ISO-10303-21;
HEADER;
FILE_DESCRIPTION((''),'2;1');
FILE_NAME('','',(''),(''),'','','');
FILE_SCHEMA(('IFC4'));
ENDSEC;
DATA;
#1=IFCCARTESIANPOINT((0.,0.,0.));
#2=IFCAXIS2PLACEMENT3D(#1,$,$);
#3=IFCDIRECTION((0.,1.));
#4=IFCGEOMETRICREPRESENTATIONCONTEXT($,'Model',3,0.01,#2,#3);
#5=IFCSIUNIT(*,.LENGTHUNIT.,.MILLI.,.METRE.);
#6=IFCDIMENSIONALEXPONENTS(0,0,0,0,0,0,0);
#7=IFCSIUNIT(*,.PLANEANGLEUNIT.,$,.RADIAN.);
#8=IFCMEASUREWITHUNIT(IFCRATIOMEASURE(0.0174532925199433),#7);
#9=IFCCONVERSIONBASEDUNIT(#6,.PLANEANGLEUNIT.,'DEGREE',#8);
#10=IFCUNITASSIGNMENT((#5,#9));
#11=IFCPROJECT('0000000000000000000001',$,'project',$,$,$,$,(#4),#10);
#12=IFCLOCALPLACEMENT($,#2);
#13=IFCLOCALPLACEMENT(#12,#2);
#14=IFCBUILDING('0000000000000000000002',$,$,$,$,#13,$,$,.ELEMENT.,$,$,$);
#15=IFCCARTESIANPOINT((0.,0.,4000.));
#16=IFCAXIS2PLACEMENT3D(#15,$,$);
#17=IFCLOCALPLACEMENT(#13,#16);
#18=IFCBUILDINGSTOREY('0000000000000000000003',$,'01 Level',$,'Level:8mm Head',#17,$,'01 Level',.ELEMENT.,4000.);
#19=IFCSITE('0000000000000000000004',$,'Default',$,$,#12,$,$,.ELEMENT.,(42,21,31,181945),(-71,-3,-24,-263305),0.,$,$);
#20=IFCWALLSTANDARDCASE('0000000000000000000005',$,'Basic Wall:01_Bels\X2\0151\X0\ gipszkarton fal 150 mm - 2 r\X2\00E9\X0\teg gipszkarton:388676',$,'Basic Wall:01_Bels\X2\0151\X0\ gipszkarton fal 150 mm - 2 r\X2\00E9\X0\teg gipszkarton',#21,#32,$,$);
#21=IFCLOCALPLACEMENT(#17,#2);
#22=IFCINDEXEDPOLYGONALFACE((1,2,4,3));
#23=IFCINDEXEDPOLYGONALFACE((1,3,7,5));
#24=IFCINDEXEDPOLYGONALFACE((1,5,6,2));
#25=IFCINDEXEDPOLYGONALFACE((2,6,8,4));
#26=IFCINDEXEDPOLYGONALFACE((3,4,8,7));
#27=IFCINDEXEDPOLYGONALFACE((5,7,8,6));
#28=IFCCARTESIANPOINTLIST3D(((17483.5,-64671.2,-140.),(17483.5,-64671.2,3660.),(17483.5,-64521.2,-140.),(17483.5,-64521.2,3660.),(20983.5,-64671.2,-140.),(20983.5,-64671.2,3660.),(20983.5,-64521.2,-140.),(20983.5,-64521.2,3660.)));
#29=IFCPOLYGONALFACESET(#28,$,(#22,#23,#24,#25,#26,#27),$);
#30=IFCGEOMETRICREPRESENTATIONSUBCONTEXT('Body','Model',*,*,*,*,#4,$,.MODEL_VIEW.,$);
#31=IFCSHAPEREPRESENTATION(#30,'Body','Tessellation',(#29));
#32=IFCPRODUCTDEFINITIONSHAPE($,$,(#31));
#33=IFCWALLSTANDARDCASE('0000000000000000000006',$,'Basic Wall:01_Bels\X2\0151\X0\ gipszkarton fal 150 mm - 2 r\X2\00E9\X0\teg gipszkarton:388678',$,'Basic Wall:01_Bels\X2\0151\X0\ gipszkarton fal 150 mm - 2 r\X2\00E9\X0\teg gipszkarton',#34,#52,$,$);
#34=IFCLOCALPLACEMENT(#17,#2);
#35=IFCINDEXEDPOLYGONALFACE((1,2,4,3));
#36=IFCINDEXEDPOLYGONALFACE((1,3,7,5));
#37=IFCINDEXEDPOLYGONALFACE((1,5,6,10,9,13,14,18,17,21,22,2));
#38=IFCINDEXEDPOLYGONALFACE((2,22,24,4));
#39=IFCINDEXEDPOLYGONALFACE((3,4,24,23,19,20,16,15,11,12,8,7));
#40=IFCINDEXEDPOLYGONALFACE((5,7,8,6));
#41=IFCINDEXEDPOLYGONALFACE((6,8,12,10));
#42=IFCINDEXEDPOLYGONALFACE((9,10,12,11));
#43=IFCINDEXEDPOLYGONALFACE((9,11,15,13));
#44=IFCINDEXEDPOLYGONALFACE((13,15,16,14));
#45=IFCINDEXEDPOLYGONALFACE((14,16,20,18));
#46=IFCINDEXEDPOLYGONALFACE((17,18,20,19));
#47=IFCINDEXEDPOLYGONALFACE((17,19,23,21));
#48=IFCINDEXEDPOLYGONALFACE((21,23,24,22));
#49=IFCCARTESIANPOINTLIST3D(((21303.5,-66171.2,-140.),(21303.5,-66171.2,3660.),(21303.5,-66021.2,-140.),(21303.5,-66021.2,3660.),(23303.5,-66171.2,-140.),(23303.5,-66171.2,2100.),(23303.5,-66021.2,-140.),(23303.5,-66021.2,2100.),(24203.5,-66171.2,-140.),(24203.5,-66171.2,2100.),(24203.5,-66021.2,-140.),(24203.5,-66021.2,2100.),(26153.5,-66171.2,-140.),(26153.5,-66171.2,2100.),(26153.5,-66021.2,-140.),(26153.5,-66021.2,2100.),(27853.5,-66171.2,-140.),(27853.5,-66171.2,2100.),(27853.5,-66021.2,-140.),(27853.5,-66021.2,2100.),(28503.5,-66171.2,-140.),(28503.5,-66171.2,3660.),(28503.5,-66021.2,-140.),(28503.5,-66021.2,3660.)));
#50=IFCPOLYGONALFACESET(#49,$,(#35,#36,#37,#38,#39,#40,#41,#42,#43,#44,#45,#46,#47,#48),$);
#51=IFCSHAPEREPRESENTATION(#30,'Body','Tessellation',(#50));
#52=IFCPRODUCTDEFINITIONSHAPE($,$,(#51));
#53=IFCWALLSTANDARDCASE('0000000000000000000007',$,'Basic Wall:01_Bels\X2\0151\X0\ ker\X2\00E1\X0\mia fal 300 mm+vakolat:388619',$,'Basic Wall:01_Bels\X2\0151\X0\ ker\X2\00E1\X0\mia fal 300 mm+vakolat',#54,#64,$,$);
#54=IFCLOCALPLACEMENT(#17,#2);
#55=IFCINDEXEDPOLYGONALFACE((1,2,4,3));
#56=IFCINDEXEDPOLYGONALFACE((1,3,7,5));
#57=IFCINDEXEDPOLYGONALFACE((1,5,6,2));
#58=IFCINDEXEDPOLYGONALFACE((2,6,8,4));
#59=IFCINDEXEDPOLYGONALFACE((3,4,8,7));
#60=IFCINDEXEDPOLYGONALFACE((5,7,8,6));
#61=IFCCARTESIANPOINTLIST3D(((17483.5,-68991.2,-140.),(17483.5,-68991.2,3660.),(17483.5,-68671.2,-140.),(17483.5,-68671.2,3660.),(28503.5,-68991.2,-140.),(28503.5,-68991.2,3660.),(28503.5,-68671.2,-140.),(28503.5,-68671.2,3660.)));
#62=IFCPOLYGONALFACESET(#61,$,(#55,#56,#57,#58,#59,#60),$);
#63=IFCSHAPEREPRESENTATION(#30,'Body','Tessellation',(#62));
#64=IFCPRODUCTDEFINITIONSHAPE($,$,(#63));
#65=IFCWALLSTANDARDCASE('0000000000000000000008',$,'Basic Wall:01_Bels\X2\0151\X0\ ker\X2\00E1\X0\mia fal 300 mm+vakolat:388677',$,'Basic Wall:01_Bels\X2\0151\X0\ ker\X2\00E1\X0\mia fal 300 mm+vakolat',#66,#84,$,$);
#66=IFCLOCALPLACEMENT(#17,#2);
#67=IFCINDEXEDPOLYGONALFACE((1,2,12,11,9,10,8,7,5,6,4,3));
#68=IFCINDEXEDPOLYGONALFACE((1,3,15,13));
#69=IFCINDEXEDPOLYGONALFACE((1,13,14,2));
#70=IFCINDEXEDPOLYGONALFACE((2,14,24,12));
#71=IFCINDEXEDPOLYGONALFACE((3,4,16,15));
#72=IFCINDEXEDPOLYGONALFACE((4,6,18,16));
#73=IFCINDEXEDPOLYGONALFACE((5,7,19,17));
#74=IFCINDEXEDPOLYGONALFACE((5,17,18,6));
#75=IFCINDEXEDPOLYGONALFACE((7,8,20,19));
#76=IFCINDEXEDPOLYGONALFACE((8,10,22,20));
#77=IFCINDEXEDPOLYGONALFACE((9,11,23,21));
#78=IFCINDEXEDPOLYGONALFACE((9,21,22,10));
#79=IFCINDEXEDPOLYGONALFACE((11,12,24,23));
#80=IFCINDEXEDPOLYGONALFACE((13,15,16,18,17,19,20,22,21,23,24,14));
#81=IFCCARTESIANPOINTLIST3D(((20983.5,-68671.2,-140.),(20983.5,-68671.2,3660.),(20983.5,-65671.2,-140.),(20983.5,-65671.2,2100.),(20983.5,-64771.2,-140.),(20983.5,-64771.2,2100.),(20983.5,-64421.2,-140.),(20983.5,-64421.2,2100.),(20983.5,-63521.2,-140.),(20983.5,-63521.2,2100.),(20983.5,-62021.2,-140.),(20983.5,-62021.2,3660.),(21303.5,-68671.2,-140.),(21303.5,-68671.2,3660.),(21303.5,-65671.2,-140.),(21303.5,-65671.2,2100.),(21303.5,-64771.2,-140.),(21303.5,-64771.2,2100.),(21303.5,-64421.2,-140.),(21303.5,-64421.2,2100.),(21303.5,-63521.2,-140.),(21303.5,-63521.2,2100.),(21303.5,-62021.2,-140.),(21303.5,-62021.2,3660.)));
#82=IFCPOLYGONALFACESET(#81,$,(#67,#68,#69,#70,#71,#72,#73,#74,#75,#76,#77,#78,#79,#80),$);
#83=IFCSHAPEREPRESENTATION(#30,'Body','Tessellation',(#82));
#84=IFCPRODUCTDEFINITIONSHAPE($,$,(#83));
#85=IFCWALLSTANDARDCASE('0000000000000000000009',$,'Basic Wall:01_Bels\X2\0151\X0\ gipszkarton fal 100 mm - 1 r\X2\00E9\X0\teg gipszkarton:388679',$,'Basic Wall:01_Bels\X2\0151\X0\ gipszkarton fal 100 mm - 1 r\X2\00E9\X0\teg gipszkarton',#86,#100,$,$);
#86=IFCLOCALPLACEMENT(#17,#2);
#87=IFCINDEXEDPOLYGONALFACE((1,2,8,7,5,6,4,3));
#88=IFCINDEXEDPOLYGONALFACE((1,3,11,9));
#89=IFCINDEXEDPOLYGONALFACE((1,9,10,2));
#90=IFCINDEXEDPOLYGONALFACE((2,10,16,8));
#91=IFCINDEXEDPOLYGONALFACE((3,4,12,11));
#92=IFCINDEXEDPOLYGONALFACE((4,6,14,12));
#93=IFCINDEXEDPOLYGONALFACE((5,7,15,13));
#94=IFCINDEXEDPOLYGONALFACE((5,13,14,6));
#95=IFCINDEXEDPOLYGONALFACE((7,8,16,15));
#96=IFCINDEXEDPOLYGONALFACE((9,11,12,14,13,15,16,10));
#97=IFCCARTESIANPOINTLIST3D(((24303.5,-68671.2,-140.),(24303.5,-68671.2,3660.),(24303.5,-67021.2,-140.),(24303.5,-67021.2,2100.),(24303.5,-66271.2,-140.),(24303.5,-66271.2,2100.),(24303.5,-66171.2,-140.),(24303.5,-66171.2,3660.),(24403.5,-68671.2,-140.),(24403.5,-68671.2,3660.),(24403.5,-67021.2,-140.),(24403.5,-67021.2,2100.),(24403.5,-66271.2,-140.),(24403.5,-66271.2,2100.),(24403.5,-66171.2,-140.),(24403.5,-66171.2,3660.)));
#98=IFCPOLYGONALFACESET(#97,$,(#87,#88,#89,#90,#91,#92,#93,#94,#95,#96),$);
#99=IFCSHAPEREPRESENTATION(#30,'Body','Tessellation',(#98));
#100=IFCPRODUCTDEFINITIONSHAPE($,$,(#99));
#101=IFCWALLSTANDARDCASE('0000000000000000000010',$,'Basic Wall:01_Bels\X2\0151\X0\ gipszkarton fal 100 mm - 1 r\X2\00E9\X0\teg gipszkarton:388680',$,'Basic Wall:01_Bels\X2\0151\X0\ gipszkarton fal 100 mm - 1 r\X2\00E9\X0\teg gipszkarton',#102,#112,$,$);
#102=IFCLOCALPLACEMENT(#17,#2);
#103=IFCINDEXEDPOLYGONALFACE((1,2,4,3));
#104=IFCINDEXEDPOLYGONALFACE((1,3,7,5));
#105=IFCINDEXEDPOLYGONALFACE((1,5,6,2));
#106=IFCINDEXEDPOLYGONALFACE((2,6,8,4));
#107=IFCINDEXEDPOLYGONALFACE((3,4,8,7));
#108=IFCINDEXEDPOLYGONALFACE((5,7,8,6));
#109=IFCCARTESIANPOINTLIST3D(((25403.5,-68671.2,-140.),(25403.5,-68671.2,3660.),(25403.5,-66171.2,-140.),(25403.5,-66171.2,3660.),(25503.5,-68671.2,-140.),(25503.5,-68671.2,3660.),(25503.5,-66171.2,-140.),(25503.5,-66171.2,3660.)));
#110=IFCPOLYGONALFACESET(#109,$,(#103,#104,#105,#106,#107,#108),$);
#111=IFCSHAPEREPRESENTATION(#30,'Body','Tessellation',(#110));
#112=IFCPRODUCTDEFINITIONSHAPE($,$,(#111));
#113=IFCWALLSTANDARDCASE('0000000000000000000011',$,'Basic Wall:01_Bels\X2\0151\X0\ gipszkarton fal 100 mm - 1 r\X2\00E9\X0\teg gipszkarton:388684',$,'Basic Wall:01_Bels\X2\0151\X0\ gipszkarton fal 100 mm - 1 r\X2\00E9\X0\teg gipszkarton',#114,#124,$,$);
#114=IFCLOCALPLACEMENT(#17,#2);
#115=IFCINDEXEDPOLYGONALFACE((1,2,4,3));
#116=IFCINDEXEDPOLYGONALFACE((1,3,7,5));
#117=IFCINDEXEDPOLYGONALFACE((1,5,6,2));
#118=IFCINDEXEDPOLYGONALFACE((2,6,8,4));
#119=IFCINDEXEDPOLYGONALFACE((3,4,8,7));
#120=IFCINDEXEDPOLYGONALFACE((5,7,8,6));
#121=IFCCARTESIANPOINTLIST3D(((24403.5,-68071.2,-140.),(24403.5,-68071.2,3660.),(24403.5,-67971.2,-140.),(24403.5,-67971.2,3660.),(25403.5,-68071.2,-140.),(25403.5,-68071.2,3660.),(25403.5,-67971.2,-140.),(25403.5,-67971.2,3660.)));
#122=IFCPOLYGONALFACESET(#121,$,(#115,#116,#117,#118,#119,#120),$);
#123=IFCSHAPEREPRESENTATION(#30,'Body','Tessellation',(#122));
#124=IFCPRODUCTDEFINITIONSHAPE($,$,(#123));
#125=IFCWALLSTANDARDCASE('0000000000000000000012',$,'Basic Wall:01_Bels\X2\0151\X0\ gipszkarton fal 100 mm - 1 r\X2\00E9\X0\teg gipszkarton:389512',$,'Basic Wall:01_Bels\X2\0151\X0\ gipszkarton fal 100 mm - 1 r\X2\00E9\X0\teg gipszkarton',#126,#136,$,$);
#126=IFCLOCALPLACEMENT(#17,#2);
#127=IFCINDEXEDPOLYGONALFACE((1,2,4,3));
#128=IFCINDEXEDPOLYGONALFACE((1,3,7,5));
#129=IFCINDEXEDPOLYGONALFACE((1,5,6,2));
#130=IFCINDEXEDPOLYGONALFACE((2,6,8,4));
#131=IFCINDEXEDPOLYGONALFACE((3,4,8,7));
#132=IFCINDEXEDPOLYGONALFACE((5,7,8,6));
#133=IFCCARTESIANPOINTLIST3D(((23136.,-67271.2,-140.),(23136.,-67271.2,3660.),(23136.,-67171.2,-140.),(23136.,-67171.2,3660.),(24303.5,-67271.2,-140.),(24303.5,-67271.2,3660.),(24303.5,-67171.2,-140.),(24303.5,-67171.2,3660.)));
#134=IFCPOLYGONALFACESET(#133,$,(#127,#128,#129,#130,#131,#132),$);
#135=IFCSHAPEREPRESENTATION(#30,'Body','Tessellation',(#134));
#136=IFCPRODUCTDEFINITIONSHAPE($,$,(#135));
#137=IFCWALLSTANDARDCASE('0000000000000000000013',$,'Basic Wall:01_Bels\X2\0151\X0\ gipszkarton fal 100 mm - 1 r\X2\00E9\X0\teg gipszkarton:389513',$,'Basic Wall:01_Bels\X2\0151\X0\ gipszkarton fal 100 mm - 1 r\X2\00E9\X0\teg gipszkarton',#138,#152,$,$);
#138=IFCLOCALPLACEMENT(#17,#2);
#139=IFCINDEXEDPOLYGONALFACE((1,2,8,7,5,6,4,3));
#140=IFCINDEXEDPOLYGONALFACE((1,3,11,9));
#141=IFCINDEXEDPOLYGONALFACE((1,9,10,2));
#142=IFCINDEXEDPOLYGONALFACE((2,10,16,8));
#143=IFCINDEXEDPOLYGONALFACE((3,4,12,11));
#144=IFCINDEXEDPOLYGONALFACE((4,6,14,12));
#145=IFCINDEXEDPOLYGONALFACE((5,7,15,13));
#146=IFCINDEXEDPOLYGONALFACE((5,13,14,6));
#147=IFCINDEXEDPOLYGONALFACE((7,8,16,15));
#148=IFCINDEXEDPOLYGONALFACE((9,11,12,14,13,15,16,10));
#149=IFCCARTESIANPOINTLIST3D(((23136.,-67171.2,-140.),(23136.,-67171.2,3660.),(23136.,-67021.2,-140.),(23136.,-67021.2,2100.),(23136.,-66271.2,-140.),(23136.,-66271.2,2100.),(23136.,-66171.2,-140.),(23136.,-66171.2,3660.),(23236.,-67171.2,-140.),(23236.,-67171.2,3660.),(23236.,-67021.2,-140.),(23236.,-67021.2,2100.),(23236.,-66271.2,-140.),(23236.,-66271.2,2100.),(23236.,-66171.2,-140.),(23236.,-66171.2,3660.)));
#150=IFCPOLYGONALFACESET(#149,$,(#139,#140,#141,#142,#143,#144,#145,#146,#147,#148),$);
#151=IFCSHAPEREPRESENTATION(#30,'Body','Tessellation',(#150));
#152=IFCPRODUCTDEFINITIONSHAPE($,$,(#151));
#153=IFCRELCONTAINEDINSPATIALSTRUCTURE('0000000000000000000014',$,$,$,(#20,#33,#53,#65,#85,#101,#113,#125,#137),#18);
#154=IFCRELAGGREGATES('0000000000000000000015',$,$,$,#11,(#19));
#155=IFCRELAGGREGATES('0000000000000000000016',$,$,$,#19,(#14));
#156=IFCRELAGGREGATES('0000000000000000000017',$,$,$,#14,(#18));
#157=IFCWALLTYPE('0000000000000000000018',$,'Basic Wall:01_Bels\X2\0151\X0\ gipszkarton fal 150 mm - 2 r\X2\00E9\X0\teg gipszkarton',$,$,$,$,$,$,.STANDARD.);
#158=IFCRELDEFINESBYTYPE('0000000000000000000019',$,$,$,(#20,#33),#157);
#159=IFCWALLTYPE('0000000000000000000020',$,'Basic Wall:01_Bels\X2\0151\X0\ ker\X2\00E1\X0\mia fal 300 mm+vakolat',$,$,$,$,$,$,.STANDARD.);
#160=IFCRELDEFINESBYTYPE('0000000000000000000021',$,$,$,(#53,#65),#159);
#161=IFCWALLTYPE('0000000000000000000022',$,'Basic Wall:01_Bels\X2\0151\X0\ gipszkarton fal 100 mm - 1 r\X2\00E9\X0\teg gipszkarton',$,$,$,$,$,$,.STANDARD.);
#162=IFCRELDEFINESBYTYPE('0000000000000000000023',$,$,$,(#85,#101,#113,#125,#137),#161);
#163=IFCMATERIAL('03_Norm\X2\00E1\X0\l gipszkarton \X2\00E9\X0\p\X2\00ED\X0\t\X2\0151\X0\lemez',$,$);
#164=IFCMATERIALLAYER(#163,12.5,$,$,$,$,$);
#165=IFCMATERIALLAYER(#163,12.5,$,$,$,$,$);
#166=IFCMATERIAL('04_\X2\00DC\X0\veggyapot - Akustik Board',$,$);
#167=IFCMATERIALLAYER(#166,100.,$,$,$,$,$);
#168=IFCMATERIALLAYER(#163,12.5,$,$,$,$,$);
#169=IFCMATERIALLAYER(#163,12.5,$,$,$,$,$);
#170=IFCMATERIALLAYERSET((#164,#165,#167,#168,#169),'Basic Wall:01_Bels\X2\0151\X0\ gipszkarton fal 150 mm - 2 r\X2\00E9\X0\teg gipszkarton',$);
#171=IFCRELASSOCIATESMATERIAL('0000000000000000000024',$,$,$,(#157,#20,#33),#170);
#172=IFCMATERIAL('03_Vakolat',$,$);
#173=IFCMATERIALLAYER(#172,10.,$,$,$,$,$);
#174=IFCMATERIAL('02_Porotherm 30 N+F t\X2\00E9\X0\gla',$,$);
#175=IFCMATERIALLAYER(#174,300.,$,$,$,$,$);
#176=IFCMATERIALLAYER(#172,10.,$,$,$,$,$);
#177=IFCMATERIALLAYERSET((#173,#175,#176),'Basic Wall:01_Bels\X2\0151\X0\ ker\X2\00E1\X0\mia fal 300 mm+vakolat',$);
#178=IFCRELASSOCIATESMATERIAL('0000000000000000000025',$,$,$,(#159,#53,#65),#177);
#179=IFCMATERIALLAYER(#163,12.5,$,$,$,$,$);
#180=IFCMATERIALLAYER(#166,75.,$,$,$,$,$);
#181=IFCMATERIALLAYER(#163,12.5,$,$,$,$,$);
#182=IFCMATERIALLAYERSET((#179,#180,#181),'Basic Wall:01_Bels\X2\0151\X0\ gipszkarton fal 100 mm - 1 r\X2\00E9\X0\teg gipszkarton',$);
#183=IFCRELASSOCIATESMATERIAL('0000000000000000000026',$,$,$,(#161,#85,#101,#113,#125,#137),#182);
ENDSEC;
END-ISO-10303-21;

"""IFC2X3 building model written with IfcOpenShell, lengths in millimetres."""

from ifc_helpers import new_model, entity, si_unit, converted_unit, direction, frame, frame_2d, origin, origin_2d_with_axis, place, context, subcontext, project, spatial, rectangle, extrude, material, layer, layer_set, layer_usage, type_object, element, save


model = new_model("IFC2X3")

# Units and contexts
model_context = context("Model", 3, precision=0.01, world=origin(), true_north=direction((0.0, 1.0)))
body_context = subcontext(model_context, "Body", "Model", "MODEL_VIEW")
ifc_project = project(units=[si_unit("LENGTHUNIT", "METRE", prefix="MILLI"), converted_unit("PLANEANGLEUNIT", "DEGREE", entity("IfcRatioMeasure", 0.0174532925199433), si_unit("PLANEANGLEUNIT", "RADIAN"), dimensions=[0, 0, 0, 0, 0, 0, 0])], contexts=[model_context])

# Site, building, storey
site_placement = place(None, origin())
site = spatial("IfcSite", under=ifc_project, at=site_placement, Name="Default", CompositionType="ELEMENT", RefLatitude=(42, 21, 31, 181945), RefLongitude=(-71, -3, -24, -263305), RefElevation=0.0)
building_placement = place(site_placement, origin())
building = spatial("IfcBuilding", under=site, at=building_placement, CompositionType="ELEMENT")
storey_placement = place(building_placement, frame((0.0, 0.0, 4000.0)))
storey = spatial("IfcBuildingStorey", under=building, at=storey_placement, Name="01 Level", ObjectType="Level:8mm Head", LongName="01 Level", CompositionType="ELEMENT", Elevation=4000.0)

# Wall
ifc_material_1 = material(Name="03_Normál gipszkarton építőlemez")
ifc_layer_1 = layer(ifc_material_1, 12.5)
ifc_layer_2 = layer(ifc_material_1, 12.5)
ifc_material_2 = material(Name="04_Üveggyapot - Akustik Board")
ifc_layer_3 = layer(ifc_material_2, 100.0)
ifc_layer_4 = layer(ifc_material_1, 12.5)
ifc_layer_5 = layer(ifc_material_1, 12.5)
ifc_layer_set_1 = layer_set([ifc_layer_1, ifc_layer_2, ifc_layer_3, ifc_layer_4, ifc_layer_5], Name="Basic Wall:01_Belső gipszkarton fal 150 mm - 2 réteg gipszkarton")
ifc_layer_usage_1 = layer_usage(ifc_layer_set_1, "AXIS2", "POSITIVE", -75.0)
wall_type_1 = type_object("IfcWallType", Name="Basic Wall:01_Belső gipszkarton fal 150 mm - 2 réteg gipszkarton", PredefinedType="STANDARD", material=ifc_layer_set_1)
wall_1_placement = place(storey_placement, frame((17483.5, -64596.2, -140.0)))
element("IfcWallStandardCase", 1, at=wall_1_placement, inside=storey, type_object=wall_type_1, material=ifc_layer_usage_1, Name="Basic Wall:01_Belső gipszkarton fal 150 mm - 2 réteg gipszkarton:388676", ObjectType="Basic Wall:01_Belső gipszkarton fal 150 mm - 2 réteg gipszkarton", context=body_context, shape_type="SweptSolid", body=[
    extrude(rectangle(XDim=3500.0, YDim=150.0, at=frame_2d((1750.0, 0.0), x_axis=(-1.0, 0.0))), origin(), (0.0, 0.0, 1.0), 3800.0),
])

# Wall, openings
ifc_layer_usage_2 = layer_usage(ifc_layer_set_1, "AXIS2", "POSITIVE", -75.0)
wall_2_placement = place(storey_placement, frame((21303.5, -66096.2, -140.0)))
wall_2 = element("IfcWallStandardCase", 2, at=wall_2_placement, inside=storey, type_object=wall_type_1, material=ifc_layer_usage_2, Name="Basic Wall:01_Belső gipszkarton fal 150 mm - 2 réteg gipszkarton:388678", ObjectType="Basic Wall:01_Belső gipszkarton fal 150 mm - 2 réteg gipszkarton", context=body_context, shape_type="SweptSolid", body=[
    extrude(rectangle(XDim=7200.0, YDim=150.0, at=frame_2d((3600.0, 0.0), x_axis=(-1.0, 0.0))), origin(), (0.0, 0.0, 1.0), 3800.0),
])
opening_1_placement = place(wall_2_placement, frame((4850.0, -75.0, 0.0)))
element("IfcOpeningElement", 3, at=opening_1_placement, cuts=wall_2, ObjectType="Opening", context=body_context, shape_type="SweptSolid", body=[
    extrude(rectangle(XDim=2240.0, YDim=1700.0, at=frame_2d((0.0, 0.0), x_axis=(1.0, 0.0))), frame((850.0, 0.0, 1120.0), z_axis=(0.0, 1.0, 0.0), x_axis=(0.0, 0.0, -1.0)), (0.0, 0.0, 1.0), 150.0),
])
opening_2_placement = place(wall_2_placement, frame((2000.0, -1599.0, 0.0)))
element("IfcOpeningElement", 4, at=opening_2_placement, cuts=wall_2, ObjectType="Opening", context=body_context, shape_type="SweptSolid", body=[
    extrude(rectangle(XDim=2240.0, YDim=900.0, at=frame_2d((0.0, 0.0), x_axis=(0.0, 1.0))), frame((450.0, 0.0, 1120.0), z_axis=(0.0, 1.0, 0.0), x_axis=(-1.0, 0.0, 0.0)), (0.0, 0.0, 1.0), 3048.0),
])

# Wall
ifc_material_3 = material(Name="03_Vakolat")
ifc_layer_6 = layer(ifc_material_3, 10.0)
ifc_material_4 = material(Name="02_Porotherm 30 N+F tégla")
ifc_layer_7 = layer(ifc_material_4, 300.0)
ifc_layer_8 = layer(ifc_material_3, 10.0)
ifc_layer_set_2 = layer_set([ifc_layer_6, ifc_layer_7, ifc_layer_8], Name="Basic Wall:01_Belső kerámia fal 300 mm+vakolat")
ifc_layer_usage_3 = layer_usage(ifc_layer_set_2, "AXIS2", "NEGATIVE", 160.0)
wall_type_2 = type_object("IfcWallType", Name="Basic Wall:01_Belső kerámia fal 300 mm+vakolat", PredefinedType="STANDARD", material=ifc_layer_set_2)
wall_3_placement = place(storey_placement, frame((17483.5, -68831.2, -140.0)))
element("IfcWallStandardCase", 5, at=wall_3_placement, inside=storey, type_object=wall_type_2, material=ifc_layer_usage_3, Name="Basic Wall:01_Belső kerámia fal 300 mm+vakolat:388619", ObjectType="Basic Wall:01_Belső kerámia fal 300 mm+vakolat", context=body_context, shape_type="SweptSolid", body=[
    extrude(rectangle(XDim=11020.0, YDim=320.0, at=frame_2d((5510.0, 0.0), x_axis=(-1.0, 0.0))), origin(), (0.0, 0.0, 1.0), 3800.0),
])

# Wall, openings
ifc_layer_usage_4 = layer_usage(ifc_layer_set_2, "AXIS2", "POSITIVE", -160.0)
wall_4_placement = place(storey_placement, frame((21143.5, -68671.2, -140.0), z_axis=(0.0, 0.0, 1.0), x_axis=(0.0, 1.0, 0.0)))
wall_4 = element("IfcWallStandardCase", 6, at=wall_4_placement, inside=storey, type_object=wall_type_2, material=ifc_layer_usage_4, Name="Basic Wall:01_Belső kerámia fal 300 mm+vakolat:388677", ObjectType="Basic Wall:01_Belső kerámia fal 300 mm+vakolat", context=body_context, shape_type="SweptSolid", body=[
    extrude(rectangle(XDim=6650.0, YDim=320.0, at=frame_2d((3325.0, 0.0), x_axis=(-1.0, 0.0))), origin(), (0.0, 0.0, 1.0), 3800.0),
])
opening_3_placement = place(wall_4_placement, frame((3000.0, 1364.0, 0.0), z_axis=(0.0, 0.0, 1.0), x_axis=(0.0, -1.0, 0.0)))
element("IfcOpeningElement", 7, at=opening_3_placement, cuts=wall_4, ObjectType="Opening", context=body_context, shape_type="SweptSolid", body=[
    extrude(rectangle(XDim=2240.0, YDim=900.0, at=origin_2d_with_axis()), frame((3048.0, 450.0, 1120.0), z_axis=(-1.0, 0.0, 0.0), x_axis=(0.0, 0.0, 1.0)), (0.0, 0.0, 1.0), 3048.0),
])
opening_4_placement = place(wall_4_placement, frame((4250.0, 1364.0, 0.0), z_axis=(0.0, 0.0, 1.0), x_axis=(0.0, -1.0, 0.0)))
element("IfcOpeningElement", 8, at=opening_4_placement, cuts=wall_4, ObjectType="Opening", context=body_context, shape_type="SweptSolid", body=[
    extrude(rectangle(XDim=2240.0, YDim=900.0, at=frame_2d((0.0, 0.0), x_axis=(0.0, 1.0))), frame((3048.0, 450.0, 1120.0), z_axis=(-1.0, 0.0, 0.0), x_axis=(0.0, -1.0, 0.0)), (0.0, 0.0, 1.0), 3048.0),
])

# Wall, opening
ifc_layer_9 = layer(ifc_material_1, 12.5)
ifc_layer_10 = layer(ifc_material_2, 75.0)
ifc_layer_11 = layer(ifc_material_1, 12.5)
ifc_layer_set_3 = layer_set([ifc_layer_9, ifc_layer_10, ifc_layer_11], Name="Basic Wall:01_Belső gipszkarton fal 100 mm - 1 réteg gipszkarton")
ifc_layer_usage_5 = layer_usage(ifc_layer_set_3, "AXIS2", "POSITIVE", -50.0)
wall_type_3 = type_object("IfcWallType", Name="Basic Wall:01_Belső gipszkarton fal 100 mm - 1 réteg gipszkarton", PredefinedType="STANDARD", material=ifc_layer_set_3)
wall_5_placement = place(storey_placement, frame((24353.5, -66171.2, -140.0), z_axis=(0.0, 0.0, 1.0), x_axis=(0.0, -1.0, 0.0)))
wall_5 = element("IfcWallStandardCase", 9, at=wall_5_placement, inside=storey, type_object=wall_type_3, material=ifc_layer_usage_5, Name="Basic Wall:01_Belső gipszkarton fal 100 mm - 1 réteg gipszkarton:388679", ObjectType="Basic Wall:01_Belső gipszkarton fal 100 mm - 1 réteg gipszkarton", context=body_context, shape_type="SweptSolid", body=[
    extrude(rectangle(XDim=2500.0, YDim=100.0, at=frame_2d((1250.0, 0.0), x_axis=(-1.0, 0.0))), origin(), (0.0, 0.0, 1.0), 3800.0),
])
opening_5_placement = place(wall_5_placement, frame((850.0, -1574.0, 0.0), z_axis=(0.0, 0.0, 1.0), x_axis=(0.0, 1.0, 0.0)))
element("IfcOpeningElement", 10, at=opening_5_placement, cuts=wall_5, ObjectType="Opening", context=body_context, shape_type="SweptSolid", body=[
    extrude(rectangle(XDim=2240.0, YDim=750.0, at=frame_2d((0.0, 0.0), x_axis=(0.0, 1.0))), frame((0.0, 375.0, 1120.0), z_axis=(1.0, 0.0, 0.0), x_axis=(0.0, 1.0, 0.0)), (0.0, 0.0, 1.0), 3048.0),
])

# Walls
ifc_layer_usage_6 = layer_usage(ifc_layer_set_3, "AXIS2", "POSITIVE", -50.0)
wall_6_placement = place(storey_placement, frame((25453.5, -66171.2, -140.0), z_axis=(0.0, 0.0, 1.0), x_axis=(0.0, -1.0, 0.0)))
element("IfcWallStandardCase", 11, at=wall_6_placement, inside=storey, type_object=wall_type_3, material=ifc_layer_usage_6, Name="Basic Wall:01_Belső gipszkarton fal 100 mm - 1 réteg gipszkarton:388680", ObjectType="Basic Wall:01_Belső gipszkarton fal 100 mm - 1 réteg gipszkarton", context=body_context, shape_type="SweptSolid", body=[
    extrude(rectangle(XDim=2500.0, YDim=100.0, at=frame_2d((1250.0, 0.0), x_axis=(-1.0, 0.0))), origin(), (0.0, 0.0, 1.0), 3800.0),
])
ifc_layer_usage_7 = layer_usage(ifc_layer_set_3, "AXIS2", "POSITIVE", -50.0)
wall_7_placement = place(storey_placement, frame((24403.5, -68021.2, -140.0)))
element("IfcWallStandardCase", 12, at=wall_7_placement, inside=storey, type_object=wall_type_3, material=ifc_layer_usage_7, Name="Basic Wall:01_Belső gipszkarton fal 100 mm - 1 réteg gipszkarton:388684", ObjectType="Basic Wall:01_Belső gipszkarton fal 100 mm - 1 réteg gipszkarton", context=body_context, shape_type="SweptSolid", body=[
    extrude(rectangle(XDim=1000.0, YDim=100.0, at=frame_2d((500.0, 0.0), x_axis=(-1.0, 0.0))), origin(), (0.0, 0.0, 1.0), 3800.0),
])
ifc_layer_usage_8 = layer_usage(ifc_layer_set_3, "AXIS2", "POSITIVE", -50.0)
wall_8_placement = place(storey_placement, frame((24303.5, -67221.2, -140.0), z_axis=(0.0, 0.0, 1.0), x_axis=(-1.0, 0.0, 0.0)))
element("IfcWallStandardCase", 13, at=wall_8_placement, inside=storey, type_object=wall_type_3, material=ifc_layer_usage_8, Name="Basic Wall:01_Belső gipszkarton fal 100 mm - 1 réteg gipszkarton:389512", ObjectType="Basic Wall:01_Belső gipszkarton fal 100 mm - 1 réteg gipszkarton", context=body_context, shape_type="SweptSolid", body=[
    extrude(rectangle(XDim=1167.5, YDim=100.0, at=frame_2d((583.8, 0.0), x_axis=(-1.0, 0.0))), origin(), (0.0, 0.0, 1.0), 3800.0),
])

# Wall, opening
ifc_layer_usage_9 = layer_usage(ifc_layer_set_3, "AXIS2", "POSITIVE", -50.0)
wall_9_placement = place(storey_placement, frame((23186.0, -67171.2, -140.0), z_axis=(0.0, 0.0, 1.0), x_axis=(0.0, 1.0, 0.0)))
wall_9 = element("IfcWallStandardCase", 14, at=wall_9_placement, inside=storey, type_object=wall_type_3, material=ifc_layer_usage_9, Name="Basic Wall:01_Belső gipszkarton fal 100 mm - 1 réteg gipszkarton:389513", ObjectType="Basic Wall:01_Belső gipszkarton fal 100 mm - 1 réteg gipszkarton", context=body_context, shape_type="SweptSolid", body=[
    extrude(rectangle(XDim=1000.0, YDim=100.0, at=frame_2d((500.0, 0.0), x_axis=(-1.0, 0.0))), origin(), (0.0, 0.0, 1.0), 3800.0),
])
opening_6_placement = place(wall_9_placement, frame((150.0, 1474.0, 0.0), z_axis=(0.0, 0.0, 1.0), x_axis=(0.0, -1.0, 0.0)))
element("IfcOpeningElement", 15, at=opening_6_placement, cuts=wall_9, ObjectType="Opening", context=body_context, shape_type="SweptSolid", body=[
    extrude(rectangle(XDim=2240.0, YDim=750.0, at=origin_2d_with_axis()), frame((3048.0, 375.0, 1120.0), z_axis=(-1.0, 0.0, 0.0), x_axis=(0.0, 0.0, 1.0)), (0.0, 0.0, 1.0), 3048.0),
])

save(model, "model.ifc")
